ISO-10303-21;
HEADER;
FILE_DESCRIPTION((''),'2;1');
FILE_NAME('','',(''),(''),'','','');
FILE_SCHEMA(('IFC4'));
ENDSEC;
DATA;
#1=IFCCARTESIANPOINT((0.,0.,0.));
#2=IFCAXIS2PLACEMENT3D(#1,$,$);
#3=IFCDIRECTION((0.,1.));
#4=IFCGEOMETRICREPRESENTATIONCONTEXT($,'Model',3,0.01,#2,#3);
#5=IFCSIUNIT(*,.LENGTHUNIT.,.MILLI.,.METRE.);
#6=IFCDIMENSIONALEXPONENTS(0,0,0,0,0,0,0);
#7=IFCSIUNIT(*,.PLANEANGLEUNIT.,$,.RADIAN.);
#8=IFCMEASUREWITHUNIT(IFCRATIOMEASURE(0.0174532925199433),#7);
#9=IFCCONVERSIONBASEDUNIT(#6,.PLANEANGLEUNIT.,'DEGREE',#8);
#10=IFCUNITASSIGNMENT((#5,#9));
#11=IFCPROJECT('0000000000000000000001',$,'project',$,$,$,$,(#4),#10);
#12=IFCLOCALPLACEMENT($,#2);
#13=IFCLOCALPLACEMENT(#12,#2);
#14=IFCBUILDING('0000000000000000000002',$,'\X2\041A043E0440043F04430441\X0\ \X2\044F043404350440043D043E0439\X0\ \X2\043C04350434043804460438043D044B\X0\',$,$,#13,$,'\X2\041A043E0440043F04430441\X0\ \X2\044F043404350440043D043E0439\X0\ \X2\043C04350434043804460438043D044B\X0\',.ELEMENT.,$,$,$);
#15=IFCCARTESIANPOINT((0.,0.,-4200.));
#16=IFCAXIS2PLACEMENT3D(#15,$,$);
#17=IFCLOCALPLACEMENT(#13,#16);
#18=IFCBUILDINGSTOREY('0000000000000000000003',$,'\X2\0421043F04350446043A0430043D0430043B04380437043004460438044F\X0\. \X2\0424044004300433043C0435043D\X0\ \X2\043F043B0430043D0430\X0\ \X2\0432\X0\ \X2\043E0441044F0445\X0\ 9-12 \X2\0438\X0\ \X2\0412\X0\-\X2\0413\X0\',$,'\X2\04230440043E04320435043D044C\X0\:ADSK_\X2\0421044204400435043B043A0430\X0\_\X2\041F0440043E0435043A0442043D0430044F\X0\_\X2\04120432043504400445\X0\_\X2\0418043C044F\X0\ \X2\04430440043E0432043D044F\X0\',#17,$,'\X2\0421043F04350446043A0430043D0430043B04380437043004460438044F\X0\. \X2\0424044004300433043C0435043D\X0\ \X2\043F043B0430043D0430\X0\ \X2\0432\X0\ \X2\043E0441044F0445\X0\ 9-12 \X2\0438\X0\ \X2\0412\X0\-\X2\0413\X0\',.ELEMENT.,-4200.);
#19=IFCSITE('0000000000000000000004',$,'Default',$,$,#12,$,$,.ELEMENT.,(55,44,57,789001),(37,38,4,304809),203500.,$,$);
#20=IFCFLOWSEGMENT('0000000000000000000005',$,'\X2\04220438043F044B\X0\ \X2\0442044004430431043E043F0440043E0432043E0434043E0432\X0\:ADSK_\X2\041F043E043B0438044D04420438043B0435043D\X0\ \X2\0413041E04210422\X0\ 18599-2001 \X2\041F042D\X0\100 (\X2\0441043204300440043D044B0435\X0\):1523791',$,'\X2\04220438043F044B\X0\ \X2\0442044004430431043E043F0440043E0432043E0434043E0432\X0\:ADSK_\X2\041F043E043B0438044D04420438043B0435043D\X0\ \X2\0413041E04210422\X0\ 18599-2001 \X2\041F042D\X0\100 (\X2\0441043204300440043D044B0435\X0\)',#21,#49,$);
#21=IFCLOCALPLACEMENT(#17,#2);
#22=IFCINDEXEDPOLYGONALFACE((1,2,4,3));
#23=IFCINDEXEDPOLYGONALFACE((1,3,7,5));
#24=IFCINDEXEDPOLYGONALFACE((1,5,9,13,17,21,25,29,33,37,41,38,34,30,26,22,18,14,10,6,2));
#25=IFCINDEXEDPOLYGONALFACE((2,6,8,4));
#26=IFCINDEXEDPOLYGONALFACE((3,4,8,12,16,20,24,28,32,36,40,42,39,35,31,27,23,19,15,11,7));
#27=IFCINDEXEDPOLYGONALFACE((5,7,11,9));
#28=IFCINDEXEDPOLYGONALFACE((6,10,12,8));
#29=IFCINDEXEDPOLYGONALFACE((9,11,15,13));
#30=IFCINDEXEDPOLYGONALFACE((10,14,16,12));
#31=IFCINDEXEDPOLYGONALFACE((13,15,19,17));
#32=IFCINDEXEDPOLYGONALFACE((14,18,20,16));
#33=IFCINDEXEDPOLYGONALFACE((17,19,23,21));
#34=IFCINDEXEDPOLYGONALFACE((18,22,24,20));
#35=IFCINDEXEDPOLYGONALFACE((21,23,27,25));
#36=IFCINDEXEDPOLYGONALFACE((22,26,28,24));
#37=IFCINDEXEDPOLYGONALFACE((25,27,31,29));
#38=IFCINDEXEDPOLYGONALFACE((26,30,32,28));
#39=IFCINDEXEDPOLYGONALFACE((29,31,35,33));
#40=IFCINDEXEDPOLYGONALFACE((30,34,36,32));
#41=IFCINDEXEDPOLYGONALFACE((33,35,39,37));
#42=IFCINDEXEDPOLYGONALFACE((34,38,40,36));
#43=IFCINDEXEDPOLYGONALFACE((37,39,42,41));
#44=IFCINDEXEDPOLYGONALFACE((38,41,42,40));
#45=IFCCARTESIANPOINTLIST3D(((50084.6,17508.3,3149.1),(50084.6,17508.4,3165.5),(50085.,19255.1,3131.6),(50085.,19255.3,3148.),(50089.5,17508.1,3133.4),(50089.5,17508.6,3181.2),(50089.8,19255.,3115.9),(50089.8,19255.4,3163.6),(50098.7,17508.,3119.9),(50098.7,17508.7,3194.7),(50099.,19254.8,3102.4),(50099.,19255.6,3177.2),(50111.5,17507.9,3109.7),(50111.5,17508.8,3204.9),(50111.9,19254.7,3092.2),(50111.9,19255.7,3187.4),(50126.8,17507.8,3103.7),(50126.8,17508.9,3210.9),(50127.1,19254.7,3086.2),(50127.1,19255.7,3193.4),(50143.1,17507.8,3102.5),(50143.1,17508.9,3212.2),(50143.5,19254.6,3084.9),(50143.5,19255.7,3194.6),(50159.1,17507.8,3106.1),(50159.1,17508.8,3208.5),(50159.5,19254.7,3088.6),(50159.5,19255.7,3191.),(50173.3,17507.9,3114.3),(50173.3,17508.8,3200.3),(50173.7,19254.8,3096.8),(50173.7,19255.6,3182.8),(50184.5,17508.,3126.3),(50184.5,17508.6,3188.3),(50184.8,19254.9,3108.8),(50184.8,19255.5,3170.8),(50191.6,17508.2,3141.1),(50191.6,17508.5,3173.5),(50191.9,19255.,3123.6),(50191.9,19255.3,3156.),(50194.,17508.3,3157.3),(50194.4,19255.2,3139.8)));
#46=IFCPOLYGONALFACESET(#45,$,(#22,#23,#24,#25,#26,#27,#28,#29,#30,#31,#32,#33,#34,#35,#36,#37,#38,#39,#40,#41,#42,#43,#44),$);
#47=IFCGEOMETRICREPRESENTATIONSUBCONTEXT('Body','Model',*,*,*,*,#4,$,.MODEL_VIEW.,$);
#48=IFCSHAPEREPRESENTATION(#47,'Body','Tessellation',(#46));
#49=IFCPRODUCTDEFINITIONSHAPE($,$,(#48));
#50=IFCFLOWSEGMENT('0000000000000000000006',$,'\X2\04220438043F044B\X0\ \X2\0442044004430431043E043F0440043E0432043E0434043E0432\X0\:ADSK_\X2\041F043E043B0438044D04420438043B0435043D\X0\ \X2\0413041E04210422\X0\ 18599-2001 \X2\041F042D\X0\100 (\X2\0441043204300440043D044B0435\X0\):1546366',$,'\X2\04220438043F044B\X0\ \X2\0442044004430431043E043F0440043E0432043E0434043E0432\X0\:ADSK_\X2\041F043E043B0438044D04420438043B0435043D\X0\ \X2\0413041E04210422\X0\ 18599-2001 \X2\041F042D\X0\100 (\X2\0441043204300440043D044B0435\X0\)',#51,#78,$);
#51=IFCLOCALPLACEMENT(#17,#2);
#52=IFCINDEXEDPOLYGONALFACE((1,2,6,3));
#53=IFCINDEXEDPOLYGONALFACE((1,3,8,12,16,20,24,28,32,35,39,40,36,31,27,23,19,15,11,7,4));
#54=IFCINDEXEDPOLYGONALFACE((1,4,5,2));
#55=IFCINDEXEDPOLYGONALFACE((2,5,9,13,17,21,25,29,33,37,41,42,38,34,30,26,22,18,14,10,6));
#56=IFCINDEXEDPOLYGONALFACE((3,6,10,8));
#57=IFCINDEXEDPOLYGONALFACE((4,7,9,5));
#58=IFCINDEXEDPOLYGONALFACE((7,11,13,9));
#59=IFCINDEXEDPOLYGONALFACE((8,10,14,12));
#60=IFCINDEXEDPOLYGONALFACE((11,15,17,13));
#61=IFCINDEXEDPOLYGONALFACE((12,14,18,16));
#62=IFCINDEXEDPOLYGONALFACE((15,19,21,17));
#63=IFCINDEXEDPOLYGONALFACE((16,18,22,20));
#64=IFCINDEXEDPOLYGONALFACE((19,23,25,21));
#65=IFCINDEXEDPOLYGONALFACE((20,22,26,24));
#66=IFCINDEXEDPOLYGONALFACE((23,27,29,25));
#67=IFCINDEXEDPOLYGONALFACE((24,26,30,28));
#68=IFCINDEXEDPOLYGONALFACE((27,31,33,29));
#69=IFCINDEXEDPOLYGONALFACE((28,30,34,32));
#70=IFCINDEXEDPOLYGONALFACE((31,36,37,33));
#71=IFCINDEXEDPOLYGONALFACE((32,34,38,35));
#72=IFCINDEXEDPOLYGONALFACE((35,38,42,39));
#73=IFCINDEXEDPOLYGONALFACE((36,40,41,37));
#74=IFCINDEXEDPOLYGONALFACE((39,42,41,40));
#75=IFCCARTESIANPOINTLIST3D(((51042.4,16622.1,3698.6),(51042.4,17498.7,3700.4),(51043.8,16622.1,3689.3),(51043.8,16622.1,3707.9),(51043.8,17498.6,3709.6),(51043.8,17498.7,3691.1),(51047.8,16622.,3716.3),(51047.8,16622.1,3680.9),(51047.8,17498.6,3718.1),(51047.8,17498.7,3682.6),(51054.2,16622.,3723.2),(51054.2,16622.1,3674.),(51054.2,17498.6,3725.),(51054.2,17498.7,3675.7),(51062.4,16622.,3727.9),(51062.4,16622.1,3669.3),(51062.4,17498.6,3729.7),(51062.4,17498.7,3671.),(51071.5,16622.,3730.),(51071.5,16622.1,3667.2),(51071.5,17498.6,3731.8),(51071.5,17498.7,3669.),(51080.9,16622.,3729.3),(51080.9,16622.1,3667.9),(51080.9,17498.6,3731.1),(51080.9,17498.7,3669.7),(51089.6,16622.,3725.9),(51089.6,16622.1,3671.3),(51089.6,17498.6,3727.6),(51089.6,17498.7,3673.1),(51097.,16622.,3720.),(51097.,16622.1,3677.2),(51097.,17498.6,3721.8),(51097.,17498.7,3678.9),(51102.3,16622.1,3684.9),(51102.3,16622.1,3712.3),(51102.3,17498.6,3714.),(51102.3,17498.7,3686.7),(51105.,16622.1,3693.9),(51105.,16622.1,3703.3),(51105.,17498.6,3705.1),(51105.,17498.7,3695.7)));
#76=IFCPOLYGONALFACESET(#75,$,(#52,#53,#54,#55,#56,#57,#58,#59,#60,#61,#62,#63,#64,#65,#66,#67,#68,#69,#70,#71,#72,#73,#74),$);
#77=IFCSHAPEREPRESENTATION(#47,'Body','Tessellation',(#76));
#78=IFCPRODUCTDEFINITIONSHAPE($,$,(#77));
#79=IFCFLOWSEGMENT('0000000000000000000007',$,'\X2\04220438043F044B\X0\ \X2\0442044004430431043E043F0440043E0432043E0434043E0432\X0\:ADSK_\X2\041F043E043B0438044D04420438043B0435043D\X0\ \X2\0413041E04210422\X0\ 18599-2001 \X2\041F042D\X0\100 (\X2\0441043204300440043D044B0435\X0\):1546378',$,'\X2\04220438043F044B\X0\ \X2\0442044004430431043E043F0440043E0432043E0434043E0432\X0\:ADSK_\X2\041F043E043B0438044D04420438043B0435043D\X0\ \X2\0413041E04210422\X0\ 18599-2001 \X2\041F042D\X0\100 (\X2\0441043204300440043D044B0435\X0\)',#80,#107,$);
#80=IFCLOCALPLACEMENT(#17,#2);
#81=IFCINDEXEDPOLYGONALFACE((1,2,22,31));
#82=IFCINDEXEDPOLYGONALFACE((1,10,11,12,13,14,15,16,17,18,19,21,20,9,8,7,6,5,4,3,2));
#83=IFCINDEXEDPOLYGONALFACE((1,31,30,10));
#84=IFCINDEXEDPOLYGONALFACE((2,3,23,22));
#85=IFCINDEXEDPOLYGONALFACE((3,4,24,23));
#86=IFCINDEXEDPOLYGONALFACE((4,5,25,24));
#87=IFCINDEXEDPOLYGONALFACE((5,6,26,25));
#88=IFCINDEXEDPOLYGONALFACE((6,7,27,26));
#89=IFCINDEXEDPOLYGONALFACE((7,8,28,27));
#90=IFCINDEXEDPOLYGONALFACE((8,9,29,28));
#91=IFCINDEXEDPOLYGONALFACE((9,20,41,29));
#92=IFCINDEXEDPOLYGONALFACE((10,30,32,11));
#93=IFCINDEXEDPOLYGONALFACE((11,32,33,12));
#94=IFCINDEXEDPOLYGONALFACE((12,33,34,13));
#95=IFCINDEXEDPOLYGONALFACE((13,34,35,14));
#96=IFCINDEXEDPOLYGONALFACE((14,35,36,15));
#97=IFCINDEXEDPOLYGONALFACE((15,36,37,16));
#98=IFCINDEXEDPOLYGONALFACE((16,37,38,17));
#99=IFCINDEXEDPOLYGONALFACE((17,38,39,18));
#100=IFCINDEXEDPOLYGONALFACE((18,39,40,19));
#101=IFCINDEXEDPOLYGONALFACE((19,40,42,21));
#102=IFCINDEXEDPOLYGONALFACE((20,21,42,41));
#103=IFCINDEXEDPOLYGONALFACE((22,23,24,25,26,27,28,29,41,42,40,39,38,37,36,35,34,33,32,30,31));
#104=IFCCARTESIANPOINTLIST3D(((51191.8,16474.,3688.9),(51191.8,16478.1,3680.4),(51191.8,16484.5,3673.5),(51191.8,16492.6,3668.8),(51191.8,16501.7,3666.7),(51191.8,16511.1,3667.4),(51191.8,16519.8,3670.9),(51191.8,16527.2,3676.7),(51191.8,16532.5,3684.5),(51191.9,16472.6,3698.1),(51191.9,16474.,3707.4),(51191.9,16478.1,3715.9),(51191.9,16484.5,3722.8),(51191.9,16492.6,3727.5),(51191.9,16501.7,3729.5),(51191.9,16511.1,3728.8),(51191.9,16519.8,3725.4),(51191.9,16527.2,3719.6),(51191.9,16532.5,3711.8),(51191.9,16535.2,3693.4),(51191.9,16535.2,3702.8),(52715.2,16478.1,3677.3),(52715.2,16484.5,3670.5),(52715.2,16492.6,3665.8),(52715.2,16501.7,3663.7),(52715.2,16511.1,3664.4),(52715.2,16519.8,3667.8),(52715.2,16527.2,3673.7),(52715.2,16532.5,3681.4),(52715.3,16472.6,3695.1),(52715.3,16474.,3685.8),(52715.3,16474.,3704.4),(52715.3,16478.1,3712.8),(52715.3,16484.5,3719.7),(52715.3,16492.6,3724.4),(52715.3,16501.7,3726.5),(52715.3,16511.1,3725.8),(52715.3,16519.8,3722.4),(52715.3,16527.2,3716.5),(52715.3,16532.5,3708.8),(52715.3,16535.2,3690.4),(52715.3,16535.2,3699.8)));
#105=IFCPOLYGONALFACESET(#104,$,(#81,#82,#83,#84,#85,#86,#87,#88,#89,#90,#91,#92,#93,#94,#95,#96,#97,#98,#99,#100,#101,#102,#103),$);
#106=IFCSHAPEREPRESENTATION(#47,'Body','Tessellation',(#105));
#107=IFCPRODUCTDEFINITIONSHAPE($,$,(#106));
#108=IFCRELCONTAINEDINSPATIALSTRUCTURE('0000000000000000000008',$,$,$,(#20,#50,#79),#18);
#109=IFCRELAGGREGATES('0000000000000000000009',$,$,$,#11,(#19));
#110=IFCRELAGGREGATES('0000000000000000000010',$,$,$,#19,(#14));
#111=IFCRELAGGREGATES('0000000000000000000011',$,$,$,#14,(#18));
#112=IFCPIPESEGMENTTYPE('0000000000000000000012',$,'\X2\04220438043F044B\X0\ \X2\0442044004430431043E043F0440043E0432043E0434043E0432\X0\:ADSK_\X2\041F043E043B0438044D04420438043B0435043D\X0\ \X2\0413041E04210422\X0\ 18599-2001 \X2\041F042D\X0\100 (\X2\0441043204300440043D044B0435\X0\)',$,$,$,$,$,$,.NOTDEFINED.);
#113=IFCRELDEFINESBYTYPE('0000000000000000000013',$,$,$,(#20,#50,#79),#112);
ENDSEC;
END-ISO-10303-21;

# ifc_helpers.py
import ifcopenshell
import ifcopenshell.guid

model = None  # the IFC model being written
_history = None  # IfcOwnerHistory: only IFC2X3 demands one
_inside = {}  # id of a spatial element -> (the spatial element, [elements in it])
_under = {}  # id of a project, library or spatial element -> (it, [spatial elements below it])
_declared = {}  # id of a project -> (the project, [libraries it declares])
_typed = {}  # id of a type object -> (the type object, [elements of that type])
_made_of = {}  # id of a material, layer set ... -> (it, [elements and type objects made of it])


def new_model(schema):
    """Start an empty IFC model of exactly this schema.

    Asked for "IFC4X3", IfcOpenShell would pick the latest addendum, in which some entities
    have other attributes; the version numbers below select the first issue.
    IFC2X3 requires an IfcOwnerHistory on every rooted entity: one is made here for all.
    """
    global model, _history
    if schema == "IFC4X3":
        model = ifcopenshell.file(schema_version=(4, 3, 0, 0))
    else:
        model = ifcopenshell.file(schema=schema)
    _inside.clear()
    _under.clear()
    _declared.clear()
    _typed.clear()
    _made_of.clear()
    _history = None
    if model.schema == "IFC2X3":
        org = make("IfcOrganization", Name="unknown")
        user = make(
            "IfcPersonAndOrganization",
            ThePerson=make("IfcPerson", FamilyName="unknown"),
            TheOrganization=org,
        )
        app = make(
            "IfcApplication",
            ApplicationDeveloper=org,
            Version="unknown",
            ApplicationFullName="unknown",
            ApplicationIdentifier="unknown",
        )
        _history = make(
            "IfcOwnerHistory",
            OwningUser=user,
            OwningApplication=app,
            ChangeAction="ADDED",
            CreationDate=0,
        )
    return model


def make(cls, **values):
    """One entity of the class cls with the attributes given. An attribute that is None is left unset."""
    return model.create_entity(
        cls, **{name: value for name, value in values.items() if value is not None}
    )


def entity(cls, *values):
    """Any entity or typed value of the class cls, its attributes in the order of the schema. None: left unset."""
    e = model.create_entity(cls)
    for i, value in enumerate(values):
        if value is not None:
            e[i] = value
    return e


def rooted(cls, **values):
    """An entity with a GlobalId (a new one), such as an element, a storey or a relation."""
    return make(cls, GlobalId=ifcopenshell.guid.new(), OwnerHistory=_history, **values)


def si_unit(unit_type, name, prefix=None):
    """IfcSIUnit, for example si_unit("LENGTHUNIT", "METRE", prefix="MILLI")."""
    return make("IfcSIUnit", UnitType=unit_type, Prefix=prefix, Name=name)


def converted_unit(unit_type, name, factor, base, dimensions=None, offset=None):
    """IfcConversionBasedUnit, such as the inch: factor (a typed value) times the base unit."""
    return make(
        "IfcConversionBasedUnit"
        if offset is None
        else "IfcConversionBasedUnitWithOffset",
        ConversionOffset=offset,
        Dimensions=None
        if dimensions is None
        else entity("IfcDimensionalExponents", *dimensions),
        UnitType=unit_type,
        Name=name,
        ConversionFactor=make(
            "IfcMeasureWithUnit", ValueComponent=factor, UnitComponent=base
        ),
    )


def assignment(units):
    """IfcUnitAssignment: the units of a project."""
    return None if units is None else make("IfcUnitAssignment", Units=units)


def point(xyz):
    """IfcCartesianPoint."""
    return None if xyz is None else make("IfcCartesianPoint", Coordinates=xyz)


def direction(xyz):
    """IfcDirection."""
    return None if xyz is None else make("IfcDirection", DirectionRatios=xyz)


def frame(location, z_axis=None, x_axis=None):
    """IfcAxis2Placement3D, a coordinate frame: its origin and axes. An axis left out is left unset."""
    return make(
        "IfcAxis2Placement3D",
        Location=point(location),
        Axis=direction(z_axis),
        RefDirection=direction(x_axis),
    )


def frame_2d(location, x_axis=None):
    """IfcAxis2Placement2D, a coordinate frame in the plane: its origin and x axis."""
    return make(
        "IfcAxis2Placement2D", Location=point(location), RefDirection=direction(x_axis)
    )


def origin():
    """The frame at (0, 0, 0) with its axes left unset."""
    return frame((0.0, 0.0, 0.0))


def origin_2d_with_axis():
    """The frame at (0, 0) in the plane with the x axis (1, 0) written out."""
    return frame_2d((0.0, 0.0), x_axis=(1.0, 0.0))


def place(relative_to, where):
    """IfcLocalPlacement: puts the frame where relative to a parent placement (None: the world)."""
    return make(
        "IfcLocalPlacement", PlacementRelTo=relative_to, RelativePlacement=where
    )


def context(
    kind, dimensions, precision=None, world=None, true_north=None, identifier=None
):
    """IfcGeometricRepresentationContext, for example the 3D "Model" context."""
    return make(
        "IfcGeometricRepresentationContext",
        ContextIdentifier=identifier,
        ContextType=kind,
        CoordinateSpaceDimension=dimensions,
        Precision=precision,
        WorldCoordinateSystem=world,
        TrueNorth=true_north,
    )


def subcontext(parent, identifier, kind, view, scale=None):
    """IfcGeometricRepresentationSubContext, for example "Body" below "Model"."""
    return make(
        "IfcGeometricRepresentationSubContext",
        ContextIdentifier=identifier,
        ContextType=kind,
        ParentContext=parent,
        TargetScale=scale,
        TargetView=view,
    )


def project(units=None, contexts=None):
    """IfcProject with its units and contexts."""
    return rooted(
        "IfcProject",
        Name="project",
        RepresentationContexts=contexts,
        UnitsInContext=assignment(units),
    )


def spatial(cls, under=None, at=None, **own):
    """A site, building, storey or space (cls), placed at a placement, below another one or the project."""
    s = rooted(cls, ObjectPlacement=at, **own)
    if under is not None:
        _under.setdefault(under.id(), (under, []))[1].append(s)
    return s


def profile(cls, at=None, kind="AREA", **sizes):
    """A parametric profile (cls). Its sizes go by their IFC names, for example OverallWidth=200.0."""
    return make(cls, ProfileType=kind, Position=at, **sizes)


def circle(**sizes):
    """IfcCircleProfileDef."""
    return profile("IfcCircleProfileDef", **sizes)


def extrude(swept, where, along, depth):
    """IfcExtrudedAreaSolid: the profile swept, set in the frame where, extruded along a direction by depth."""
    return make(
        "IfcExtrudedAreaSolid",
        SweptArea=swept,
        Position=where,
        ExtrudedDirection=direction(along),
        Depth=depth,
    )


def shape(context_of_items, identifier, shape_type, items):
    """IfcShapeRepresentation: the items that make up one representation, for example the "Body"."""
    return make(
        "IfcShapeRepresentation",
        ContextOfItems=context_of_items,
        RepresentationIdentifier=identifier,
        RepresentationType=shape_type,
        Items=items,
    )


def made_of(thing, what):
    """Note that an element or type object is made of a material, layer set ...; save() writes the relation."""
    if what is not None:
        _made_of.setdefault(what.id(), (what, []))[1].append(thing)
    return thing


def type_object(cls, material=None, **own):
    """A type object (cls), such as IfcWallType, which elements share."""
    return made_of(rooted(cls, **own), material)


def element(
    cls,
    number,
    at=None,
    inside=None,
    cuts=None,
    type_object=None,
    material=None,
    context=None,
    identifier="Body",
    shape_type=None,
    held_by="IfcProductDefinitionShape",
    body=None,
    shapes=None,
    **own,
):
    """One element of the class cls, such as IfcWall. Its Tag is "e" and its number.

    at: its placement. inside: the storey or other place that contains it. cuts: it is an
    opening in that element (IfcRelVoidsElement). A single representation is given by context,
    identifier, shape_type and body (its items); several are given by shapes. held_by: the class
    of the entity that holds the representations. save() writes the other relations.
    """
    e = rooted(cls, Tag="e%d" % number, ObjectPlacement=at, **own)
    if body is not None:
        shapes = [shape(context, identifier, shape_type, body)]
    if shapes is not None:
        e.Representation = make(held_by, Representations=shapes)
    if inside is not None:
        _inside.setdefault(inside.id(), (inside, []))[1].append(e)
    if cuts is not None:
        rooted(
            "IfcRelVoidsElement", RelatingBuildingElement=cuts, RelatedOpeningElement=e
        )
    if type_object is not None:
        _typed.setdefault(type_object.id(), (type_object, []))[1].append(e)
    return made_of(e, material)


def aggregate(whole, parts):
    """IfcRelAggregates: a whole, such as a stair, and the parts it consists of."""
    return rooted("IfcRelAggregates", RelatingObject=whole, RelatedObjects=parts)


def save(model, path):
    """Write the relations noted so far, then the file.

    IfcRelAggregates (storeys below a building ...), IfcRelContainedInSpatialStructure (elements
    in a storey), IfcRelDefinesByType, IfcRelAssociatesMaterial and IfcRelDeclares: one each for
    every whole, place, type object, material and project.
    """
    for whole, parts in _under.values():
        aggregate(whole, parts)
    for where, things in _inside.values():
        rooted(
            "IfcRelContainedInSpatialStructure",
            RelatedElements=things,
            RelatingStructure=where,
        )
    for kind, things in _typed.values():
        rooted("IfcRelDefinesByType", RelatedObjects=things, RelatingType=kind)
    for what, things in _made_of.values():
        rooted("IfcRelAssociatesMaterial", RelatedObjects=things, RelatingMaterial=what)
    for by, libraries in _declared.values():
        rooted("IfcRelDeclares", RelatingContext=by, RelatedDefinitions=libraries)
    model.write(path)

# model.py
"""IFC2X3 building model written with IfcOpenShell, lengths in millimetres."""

from ifc_helpers import new_model, entity, si_unit, converted_unit, direction, frame, origin, origin_2d_with_axis, place, context, subcontext, project, spatial, circle, extrude, type_object, element, save


model = new_model("IFC2X3")

# Units and contexts
model_context = context("Model", 3, precision=0.01, world=origin(), true_north=direction((0.0, 1.0)))
body_context = subcontext(model_context, "Body", "Model", "MODEL_VIEW")
ifc_project = project(units=[si_unit("LENGTHUNIT", "METRE", prefix="MILLI"), converted_unit("PLANEANGLEUNIT", "DEGREE", entity("IfcRatioMeasure", 0.0174532925199433), si_unit("PLANEANGLEUNIT", "RADIAN"), dimensions=[0, 0, 0, 0, 0, 0, 0])], contexts=[model_context])

# Site, building, storey
site_placement = place(None, origin())
site = spatial("IfcSite", under=ifc_project, at=site_placement, Name="Default", CompositionType="ELEMENT", RefLatitude=(55, 44, 57, 789001), RefLongitude=(37, 38, 4, 304809), RefElevation=203500.0)
building_placement = place(site_placement, origin())
building = spatial("IfcBuilding", under=site, at=building_placement, Name="Корпус ядерной медицины", LongName="Корпус ядерной медицины", CompositionType="ELEMENT")
storey_placement = place(building_placement, frame((0.0, 0.0, -4200.0)))
storey = spatial("IfcBuildingStorey", under=building, at=storey_placement, Name="Спецканализация. Фрагмен плана в осях 9-12 и В-Г", ObjectType="Уровень:ADSK_Стрелка_Проектная_Вверх_Имя уровня", LongName="Спецканализация. Фрагмен плана в осях 9-12 и В-Г", CompositionType="ELEMENT", Elevation=-4200.0)

# Flow segments
pipe_segment_type = type_object("IfcPipeSegmentType", Name="Типы трубопроводов:ADSK_Полиэтилен ГОСТ 18599-2001 ПЭ100 (сварные)", PredefinedType="NOTDEFINED")
flow_segment_1_placement = place(storey_placement, frame((50082.4, 17506.2, 3083.2)))
element("IfcFlowSegment", 1, at=flow_segment_1_placement, inside=storey, type_object=pipe_segment_type, Name="Типы трубопроводов:ADSK_Полиэтилен ГОСТ 18599-2001 ПЭ100 (сварные):1523791", ObjectType="Типы трубопроводов:ADSK_Полиэтилен ГОСТ 18599-2001 ПЭ100 (сварные)", context=body_context, shape_type="SweptSolid", body=[
    extrude(circle(Radius=55.0, at=origin_2d_with_axis()), frame((56.6, 2.1, 74.1), z_axis=(0.000201, 0.99995, -0.010033), x_axis=(1.0, -0.000201, 0.0)), (0.0, 0.0, 1.0), 1746.9),
])
flow_segment_2_placement = place(storey_placement, frame((51040.8, 16622.0, 3665.5)))
element("IfcFlowSegment", 2, at=flow_segment_2_placement, inside=storey, type_object=pipe_segment_type, Name="Типы трубопроводов:ADSK_Полиэтилен ГОСТ 18599-2001 ПЭ100 (сварные):1546366", ObjectType="Типы трубопроводов:ADSK_Полиэтилен ГОСТ 18599-2001 ПЭ100 (сварные)", context=body_context, shape_type="SweptSolid", body=[
    extrude(circle(Radius=31.5, at=origin_2d_with_axis()), frame((33.1, 0.1, 33.1), z_axis=(0.0, 0.999998, 0.002011), x_axis=(-1.0, 0.0, 0.0)), (0.0, 0.0, 1.0), 876.6),
])
flow_segment_3_placement = place(storey_placement, frame((51191.8, 16471.0, 3662.0)))
element("IfcFlowSegment", 3, at=flow_segment_3_placement, inside=storey, type_object=pipe_segment_type, Name="Типы трубопроводов:ADSK_Полиэтилен ГОСТ 18599-2001 ПЭ100 (сварные):1546378", ObjectType="Типы трубопроводов:ADSK_Полиэтилен ГОСТ 18599-2001 ПЭ100 (сварные)", context=body_context, shape_type="SweptSolid", body=[
    extrude(circle(Radius=31.5, at=origin_2d_with_axis()), frame((1523.5, 33.1, 33.1), z_axis=(-0.999998, 0.0, 0.002), x_axis=(0.0, -1.0, 0.0)), (0.0, 0.0, 1.0), 1523.4),
])

save(model, "model.ifc")
